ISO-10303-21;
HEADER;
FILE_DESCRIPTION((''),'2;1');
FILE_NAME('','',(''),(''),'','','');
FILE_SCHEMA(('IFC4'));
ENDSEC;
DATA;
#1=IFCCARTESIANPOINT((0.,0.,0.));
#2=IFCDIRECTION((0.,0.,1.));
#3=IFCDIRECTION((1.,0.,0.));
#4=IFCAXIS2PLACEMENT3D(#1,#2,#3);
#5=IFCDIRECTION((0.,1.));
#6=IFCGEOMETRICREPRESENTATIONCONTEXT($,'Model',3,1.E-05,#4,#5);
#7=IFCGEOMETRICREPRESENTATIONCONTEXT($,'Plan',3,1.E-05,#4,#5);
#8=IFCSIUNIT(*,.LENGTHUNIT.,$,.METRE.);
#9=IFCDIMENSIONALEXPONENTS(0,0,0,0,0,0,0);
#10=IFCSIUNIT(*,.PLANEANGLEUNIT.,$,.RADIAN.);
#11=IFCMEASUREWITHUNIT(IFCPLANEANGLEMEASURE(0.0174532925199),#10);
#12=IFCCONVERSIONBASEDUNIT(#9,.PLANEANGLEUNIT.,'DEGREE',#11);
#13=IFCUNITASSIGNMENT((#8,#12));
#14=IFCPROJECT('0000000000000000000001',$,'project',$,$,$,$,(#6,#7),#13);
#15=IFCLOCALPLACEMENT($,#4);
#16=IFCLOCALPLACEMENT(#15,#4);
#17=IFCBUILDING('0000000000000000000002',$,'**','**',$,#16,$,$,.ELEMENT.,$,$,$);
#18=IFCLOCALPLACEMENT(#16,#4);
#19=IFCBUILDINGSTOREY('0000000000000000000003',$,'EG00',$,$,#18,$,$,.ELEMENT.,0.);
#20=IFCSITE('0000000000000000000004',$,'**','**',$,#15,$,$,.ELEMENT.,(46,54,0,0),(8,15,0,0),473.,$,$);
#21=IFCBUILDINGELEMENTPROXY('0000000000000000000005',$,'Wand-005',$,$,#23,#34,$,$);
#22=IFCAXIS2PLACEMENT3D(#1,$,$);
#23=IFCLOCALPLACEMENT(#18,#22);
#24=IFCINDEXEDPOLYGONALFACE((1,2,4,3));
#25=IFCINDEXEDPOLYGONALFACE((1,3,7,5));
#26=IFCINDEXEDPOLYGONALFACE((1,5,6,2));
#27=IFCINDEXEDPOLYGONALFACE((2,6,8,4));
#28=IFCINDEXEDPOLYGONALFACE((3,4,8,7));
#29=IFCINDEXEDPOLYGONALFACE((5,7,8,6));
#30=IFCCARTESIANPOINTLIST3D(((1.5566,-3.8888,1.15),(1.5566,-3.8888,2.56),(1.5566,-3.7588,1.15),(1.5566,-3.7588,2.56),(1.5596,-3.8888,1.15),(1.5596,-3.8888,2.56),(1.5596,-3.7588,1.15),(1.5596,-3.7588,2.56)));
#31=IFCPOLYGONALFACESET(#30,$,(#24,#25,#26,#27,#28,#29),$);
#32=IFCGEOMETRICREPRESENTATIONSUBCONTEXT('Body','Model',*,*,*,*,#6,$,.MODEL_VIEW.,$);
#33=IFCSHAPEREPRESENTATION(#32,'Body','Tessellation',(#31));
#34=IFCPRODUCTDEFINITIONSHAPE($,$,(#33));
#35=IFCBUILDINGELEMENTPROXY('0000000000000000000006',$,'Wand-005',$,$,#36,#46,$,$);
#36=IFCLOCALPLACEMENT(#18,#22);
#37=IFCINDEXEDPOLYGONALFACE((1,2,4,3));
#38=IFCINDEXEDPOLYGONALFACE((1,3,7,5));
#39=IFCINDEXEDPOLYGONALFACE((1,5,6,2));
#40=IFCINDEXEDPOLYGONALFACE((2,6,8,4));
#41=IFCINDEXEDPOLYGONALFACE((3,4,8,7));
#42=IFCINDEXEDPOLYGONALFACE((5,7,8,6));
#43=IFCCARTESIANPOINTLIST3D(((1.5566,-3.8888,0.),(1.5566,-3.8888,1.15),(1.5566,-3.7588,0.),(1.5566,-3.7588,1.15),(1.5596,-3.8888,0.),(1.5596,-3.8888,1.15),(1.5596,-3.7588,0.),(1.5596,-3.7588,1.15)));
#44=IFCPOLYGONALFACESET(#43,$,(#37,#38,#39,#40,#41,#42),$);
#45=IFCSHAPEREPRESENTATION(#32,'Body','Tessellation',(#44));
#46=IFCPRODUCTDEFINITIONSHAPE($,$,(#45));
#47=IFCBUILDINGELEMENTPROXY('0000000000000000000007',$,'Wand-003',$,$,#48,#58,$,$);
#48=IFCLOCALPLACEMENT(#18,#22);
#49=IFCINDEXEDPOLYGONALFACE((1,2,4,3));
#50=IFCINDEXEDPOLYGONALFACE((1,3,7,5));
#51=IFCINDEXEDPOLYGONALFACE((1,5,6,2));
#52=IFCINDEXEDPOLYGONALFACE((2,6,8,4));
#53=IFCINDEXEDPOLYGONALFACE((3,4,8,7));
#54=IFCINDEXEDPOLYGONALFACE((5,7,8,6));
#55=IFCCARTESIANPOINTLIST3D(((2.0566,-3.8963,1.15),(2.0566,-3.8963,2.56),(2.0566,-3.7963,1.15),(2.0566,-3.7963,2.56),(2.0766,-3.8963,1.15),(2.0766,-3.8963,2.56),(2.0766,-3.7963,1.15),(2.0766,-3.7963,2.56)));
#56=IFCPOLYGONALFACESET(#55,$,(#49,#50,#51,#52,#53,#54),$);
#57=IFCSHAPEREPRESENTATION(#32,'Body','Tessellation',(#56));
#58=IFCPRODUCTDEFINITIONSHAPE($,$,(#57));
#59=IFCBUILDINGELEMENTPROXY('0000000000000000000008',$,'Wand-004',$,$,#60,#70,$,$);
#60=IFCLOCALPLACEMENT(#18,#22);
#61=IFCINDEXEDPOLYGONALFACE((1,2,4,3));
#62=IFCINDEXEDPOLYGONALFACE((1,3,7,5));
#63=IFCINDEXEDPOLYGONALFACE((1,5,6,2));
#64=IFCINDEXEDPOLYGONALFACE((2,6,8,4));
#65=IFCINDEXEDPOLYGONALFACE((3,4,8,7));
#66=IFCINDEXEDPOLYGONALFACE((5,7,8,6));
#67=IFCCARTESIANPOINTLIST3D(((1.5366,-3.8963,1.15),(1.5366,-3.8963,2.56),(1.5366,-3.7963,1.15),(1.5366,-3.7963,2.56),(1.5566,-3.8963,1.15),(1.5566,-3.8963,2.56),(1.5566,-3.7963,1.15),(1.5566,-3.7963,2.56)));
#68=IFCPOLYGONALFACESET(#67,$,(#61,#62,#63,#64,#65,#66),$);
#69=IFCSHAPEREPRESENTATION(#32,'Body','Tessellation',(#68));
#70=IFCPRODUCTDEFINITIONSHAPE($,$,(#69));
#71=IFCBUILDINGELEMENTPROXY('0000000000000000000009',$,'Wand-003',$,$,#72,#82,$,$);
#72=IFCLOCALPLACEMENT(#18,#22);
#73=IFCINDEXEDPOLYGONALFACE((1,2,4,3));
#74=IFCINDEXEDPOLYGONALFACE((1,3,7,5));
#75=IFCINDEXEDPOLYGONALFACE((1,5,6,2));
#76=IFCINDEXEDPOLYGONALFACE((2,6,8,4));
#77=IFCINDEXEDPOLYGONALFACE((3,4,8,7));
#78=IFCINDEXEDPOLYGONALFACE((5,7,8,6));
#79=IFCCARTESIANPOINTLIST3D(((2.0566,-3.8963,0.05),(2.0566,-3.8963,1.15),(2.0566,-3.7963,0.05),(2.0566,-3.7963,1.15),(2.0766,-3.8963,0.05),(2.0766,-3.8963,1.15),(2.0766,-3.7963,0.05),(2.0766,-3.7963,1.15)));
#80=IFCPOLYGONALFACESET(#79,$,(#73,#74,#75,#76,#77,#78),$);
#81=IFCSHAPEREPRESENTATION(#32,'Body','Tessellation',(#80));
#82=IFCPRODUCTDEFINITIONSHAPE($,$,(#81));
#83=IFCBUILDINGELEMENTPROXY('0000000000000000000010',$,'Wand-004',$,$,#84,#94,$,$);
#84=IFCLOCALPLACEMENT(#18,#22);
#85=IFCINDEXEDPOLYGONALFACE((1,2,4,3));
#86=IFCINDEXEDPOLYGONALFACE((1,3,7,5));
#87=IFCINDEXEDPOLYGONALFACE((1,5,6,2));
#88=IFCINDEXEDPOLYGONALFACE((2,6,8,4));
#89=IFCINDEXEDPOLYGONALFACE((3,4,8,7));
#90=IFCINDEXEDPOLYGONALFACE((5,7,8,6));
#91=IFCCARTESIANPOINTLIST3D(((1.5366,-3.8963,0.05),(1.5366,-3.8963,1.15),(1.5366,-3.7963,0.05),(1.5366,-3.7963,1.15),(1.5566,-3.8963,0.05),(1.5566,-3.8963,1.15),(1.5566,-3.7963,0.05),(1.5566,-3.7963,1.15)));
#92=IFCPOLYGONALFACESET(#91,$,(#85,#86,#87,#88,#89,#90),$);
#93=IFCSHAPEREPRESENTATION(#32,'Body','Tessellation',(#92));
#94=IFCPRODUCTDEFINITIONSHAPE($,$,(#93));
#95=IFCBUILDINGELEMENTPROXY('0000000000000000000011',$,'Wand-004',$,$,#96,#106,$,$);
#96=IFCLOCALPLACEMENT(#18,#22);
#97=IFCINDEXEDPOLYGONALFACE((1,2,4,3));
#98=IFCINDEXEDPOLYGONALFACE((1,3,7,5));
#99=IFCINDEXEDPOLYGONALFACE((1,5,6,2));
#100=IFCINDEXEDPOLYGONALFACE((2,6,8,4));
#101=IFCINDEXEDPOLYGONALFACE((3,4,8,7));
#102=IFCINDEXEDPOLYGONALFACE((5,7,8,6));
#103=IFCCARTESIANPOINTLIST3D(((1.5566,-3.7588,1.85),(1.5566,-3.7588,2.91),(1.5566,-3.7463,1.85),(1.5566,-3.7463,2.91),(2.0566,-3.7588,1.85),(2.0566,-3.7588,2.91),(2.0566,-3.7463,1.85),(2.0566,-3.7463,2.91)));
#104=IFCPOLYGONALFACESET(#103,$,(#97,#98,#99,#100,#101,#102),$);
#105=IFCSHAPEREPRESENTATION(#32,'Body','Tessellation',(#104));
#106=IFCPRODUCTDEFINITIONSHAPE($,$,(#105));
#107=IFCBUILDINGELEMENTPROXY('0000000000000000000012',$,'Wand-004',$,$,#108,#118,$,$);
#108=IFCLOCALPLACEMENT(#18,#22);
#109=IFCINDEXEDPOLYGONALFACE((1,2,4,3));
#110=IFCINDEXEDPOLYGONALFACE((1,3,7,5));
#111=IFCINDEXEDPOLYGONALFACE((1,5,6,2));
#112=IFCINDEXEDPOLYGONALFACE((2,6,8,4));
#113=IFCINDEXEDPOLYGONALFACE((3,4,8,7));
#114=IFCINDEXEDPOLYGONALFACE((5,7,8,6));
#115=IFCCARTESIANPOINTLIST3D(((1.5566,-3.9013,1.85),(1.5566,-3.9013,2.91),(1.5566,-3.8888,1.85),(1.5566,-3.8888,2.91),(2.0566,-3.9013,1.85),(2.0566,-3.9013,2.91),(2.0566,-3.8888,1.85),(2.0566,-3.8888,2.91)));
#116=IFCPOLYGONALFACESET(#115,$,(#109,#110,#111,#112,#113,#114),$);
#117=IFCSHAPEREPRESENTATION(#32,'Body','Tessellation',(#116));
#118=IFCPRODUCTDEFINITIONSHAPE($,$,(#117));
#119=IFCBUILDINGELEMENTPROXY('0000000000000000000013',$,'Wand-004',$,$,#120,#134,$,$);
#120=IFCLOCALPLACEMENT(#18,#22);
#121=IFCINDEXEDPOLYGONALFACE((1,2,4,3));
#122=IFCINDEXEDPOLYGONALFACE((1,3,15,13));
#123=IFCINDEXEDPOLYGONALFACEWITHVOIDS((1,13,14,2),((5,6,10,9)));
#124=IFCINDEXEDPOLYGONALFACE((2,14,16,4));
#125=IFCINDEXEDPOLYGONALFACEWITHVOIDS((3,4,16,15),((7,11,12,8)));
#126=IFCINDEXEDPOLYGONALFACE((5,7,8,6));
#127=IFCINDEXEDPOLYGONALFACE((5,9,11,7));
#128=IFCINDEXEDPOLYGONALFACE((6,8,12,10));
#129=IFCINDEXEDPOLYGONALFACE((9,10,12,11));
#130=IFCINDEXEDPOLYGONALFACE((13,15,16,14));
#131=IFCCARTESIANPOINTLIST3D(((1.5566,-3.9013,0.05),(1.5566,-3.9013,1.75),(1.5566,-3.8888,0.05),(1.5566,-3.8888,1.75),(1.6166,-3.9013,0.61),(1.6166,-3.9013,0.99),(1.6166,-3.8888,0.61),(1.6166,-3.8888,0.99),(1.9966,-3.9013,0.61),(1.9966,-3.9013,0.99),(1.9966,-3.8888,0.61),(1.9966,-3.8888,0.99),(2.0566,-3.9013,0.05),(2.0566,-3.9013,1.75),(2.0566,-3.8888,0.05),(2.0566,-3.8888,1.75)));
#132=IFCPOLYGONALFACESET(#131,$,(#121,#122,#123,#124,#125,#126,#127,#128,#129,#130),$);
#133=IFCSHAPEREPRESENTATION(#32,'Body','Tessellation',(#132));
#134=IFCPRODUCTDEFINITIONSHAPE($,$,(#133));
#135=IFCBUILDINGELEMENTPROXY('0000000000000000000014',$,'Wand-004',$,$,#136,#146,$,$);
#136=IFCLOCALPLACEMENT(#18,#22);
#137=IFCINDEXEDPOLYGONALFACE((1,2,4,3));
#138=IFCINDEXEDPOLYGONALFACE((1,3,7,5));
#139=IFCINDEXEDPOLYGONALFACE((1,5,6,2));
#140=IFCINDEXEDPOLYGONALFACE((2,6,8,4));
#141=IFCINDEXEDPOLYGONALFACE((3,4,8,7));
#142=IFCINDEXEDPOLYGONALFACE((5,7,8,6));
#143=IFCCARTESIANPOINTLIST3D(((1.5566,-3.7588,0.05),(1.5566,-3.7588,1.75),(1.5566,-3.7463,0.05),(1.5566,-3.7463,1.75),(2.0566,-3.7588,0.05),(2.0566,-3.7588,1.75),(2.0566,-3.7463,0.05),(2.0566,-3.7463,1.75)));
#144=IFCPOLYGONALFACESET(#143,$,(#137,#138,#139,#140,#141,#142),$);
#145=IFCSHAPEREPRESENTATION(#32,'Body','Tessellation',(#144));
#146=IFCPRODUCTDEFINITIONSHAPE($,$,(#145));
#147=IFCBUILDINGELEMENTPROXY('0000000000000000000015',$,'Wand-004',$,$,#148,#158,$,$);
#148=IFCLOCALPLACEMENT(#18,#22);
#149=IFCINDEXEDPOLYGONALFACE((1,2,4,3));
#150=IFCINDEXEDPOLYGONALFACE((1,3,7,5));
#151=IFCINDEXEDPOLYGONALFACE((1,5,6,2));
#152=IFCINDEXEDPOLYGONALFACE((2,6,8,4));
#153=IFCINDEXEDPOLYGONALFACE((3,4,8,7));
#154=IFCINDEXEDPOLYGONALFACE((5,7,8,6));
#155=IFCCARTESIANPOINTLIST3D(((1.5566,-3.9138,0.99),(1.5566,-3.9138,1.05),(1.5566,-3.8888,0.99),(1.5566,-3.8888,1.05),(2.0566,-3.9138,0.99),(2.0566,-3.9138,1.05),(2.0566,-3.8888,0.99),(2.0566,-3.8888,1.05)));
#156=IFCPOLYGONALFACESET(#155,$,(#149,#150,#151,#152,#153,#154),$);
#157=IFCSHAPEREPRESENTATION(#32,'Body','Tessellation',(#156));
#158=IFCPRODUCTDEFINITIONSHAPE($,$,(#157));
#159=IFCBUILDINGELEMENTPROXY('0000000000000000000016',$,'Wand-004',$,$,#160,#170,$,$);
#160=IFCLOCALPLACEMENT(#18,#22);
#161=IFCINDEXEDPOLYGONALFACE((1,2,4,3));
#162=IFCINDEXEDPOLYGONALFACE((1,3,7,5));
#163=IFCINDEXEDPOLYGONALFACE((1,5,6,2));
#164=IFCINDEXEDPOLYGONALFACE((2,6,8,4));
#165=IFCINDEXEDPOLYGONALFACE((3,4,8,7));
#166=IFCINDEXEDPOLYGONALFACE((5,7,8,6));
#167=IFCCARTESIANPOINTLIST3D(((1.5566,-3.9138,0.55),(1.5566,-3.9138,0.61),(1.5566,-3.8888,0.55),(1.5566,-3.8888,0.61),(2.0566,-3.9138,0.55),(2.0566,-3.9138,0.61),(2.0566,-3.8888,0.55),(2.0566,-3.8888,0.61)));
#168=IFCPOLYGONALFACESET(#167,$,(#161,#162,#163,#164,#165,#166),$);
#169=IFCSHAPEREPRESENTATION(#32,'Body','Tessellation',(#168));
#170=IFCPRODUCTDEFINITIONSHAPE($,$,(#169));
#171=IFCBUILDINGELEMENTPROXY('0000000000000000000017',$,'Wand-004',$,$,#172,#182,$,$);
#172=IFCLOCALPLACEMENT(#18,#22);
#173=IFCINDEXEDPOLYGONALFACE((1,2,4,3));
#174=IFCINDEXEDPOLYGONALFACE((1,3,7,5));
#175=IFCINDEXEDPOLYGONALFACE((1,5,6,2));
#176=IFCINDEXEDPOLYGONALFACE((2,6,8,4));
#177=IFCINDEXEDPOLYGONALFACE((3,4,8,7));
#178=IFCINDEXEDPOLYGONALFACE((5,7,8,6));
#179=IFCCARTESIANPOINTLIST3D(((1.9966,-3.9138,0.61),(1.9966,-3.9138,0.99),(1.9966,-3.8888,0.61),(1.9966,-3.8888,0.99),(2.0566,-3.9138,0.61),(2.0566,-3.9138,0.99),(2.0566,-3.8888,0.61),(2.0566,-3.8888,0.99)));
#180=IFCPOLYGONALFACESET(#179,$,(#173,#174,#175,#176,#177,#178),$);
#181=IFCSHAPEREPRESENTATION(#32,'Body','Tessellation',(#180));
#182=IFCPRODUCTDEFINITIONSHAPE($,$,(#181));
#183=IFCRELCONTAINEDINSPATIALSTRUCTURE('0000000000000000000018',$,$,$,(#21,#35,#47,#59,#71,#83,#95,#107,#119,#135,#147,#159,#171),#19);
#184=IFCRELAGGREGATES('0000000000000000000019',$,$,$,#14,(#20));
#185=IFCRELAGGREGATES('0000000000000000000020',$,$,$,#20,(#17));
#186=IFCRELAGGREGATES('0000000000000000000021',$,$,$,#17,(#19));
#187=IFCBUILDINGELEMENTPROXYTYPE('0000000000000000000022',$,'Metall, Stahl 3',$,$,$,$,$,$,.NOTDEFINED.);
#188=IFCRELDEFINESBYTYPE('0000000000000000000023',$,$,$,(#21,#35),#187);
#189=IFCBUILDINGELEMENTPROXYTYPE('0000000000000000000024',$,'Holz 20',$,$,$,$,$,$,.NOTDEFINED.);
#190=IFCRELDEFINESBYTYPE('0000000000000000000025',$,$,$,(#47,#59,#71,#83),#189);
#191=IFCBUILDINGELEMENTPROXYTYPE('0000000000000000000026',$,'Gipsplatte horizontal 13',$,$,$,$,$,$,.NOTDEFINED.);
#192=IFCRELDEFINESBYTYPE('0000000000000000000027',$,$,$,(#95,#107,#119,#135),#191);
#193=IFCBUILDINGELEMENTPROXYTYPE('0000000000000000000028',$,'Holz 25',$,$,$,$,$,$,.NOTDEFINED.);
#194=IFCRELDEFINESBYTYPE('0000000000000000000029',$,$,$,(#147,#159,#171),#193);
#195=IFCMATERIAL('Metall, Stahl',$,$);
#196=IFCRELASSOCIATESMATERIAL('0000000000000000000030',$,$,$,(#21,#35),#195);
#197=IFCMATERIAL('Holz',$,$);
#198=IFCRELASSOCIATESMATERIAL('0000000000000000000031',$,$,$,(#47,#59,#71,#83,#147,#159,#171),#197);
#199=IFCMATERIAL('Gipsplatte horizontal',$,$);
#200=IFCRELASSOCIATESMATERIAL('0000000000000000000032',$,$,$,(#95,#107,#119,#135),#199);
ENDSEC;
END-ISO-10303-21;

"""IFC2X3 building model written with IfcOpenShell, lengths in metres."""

from ifc_helpers import new_model, entity, si_unit, converted_unit, direction, frame, origin_with_axes, origin_2d_with_axis, place, context, subcontext, project, spatial, polyline, rectangle, outline, extrude, material, type_object, element, save


model = new_model("IFC2X3")

# Units and contexts
model_context = context("Model", 3, precision=1e-05, world=origin_with_axes(), true_north=direction((0.0, 1.0)))
plan_context = context("Plan", 3, precision=1e-05, world=origin_with_axes(), true_north=direction((0.0, 1.0)))
body_context = subcontext(model_context, "Body", "Model", "MODEL_VIEW")
ifc_project = project(units=[si_unit("LENGTHUNIT", "METRE"), converted_unit("PLANEANGLEUNIT", "DEGREE", entity("IfcPlaneAngleMeasure", 0.0174532925199), si_unit("PLANEANGLEUNIT", "RADIAN"), dimensions=[0, 0, 0, 0, 0, 0, 0])], contexts=[model_context, plan_context])

# Site, building, storey
site_placement = place(None, origin_with_axes())
site = spatial("IfcSite", under=ifc_project, at=site_placement, Name="**", Description="**", CompositionType="ELEMENT", RefLatitude=(46, 54, 0, 0), RefLongitude=(8, 15, 0, 0), RefElevation=473.0)
building_placement = place(site_placement, origin_with_axes())
building = spatial("IfcBuilding", under=site, at=building_placement, Name="**", Description="**", CompositionType="ELEMENT")
storey_placement = place(building_placement, origin_with_axes())
storey = spatial("IfcBuildingStorey", under=building, at=storey_placement, Name="EG00", CompositionType="ELEMENT", Elevation=0.0)

# Building element proxies
ifc_material_1 = material(Name="Metall, Stahl")
building_element_proxy_type_1 = type_object("IfcBuildingElementProxyType", Name="Metall, Stahl 3", PredefinedType="NOTDEFINED")
proxy_1_placement = place(storey_placement, frame((1.5566, -3.7588, 1.15), z_axis=(0.0, 0.0, 1.0), x_axis=(0.0, -1.0, 0.0)))
element("IfcBuildingElementProxy", 1, at=proxy_1_placement, inside=storey, type_object=building_element_proxy_type_1, material=ifc_material_1, Name="Wand-005", context=body_context, shape_type="SweptSolid", body=[
    extrude(outline(polyline([(0.0, 0.0), (0.13, 0.0), (0.13, 0.003), (0.0, 0.003), (0.0, 0.0)])), origin_with_axes(), (0.0, 0.0, 1.0), 1.41),
])
proxy_2_placement = place(storey_placement, frame((1.5566, -3.7588, 0.0), z_axis=(0.0, 0.0, 1.0), x_axis=(0.0, -1.0, 0.0)))
element("IfcBuildingElementProxy", 2, at=proxy_2_placement, inside=storey, type_object=building_element_proxy_type_1, material=ifc_material_1, Name="Wand-005", context=body_context, shape_type="SweptSolid", body=[
    extrude(outline(polyline([(0.0, 0.0), (0.13, 0.0), (0.13, 0.003), (0.0, 0.003), (0.0, 0.0)])), origin_with_axes(), (0.0, 0.0, 1.0), 1.15),
])
ifc_material_2 = material(Name="Holz")
building_element_proxy_type_2 = type_object("IfcBuildingElementProxyType", Name="Holz 20", PredefinedType="NOTDEFINED")
proxy_3_placement = place(storey_placement, frame((2.0766, -3.7963, 1.15), z_axis=(0.0, 0.0, 1.0), x_axis=(0.0, -1.0, 0.0)))
element("IfcBuildingElementProxy", 3, at=proxy_3_placement, inside=storey, type_object=building_element_proxy_type_2, material=ifc_material_2, Name="Wand-003", context=body_context, shape_type="SweptSolid", body=[
    extrude(outline(polyline([(0.0, -0.02), (0.1, -0.02), (0.1, 0.0), (0.0, 0.0), (0.0, -0.02)])), origin_with_axes(), (0.0, 0.0, 1.0), 1.41),
])
proxy_4_placement = place(storey_placement, frame((1.5366, -3.7963, 1.15), z_axis=(0.0, 0.0, 1.0), x_axis=(0.0, -1.0, 0.0)))
element("IfcBuildingElementProxy", 4, at=proxy_4_placement, inside=storey, type_object=building_element_proxy_type_2, material=ifc_material_2, Name="Wand-004", context=body_context, shape_type="SweptSolid", body=[
    extrude(outline(polyline([(0.0, 0.0), (0.1, 0.0), (0.1, 0.02), (0.0, 0.02), (0.0, 0.0)])), origin_with_axes(), (0.0, 0.0, 1.0), 1.41),
])
proxy_5_placement = place(storey_placement, frame((2.0766, -3.7963, 0.05), z_axis=(0.0, 0.0, 1.0), x_axis=(0.0, -1.0, 0.0)))
element("IfcBuildingElementProxy", 5, at=proxy_5_placement, inside=storey, type_object=building_element_proxy_type_2, material=ifc_material_2, Name="Wand-003", context=body_context, shape_type="SweptSolid", body=[
    extrude(outline(polyline([(0.0, -0.02), (0.1, -0.02), (0.1, 0.0), (0.0, 0.0), (0.0, -0.02)])), origin_with_axes(), (0.0, 0.0, 1.0), 1.1),
])
proxy_6_placement = place(storey_placement, frame((1.5366, -3.7963, 0.05), z_axis=(0.0, 0.0, 1.0), x_axis=(0.0, -1.0, 0.0)))
element("IfcBuildingElementProxy", 6, at=proxy_6_placement, inside=storey, type_object=building_element_proxy_type_2, material=ifc_material_2, Name="Wand-004", context=body_context, shape_type="SweptSolid", body=[
    extrude(outline(polyline([(0.0, 0.0), (0.1, 0.0), (0.1, 0.02), (0.0, 0.02), (0.0, 0.0)])), origin_with_axes(), (0.0, 0.0, 1.0), 1.1),
])
ifc_material_3 = material(Name="Gipsplatte horizontal")
building_element_proxy_type_3 = type_object("IfcBuildingElementProxyType", Name="Gipsplatte horizontal 13", PredefinedType="NOTDEFINED")
proxy_7_placement = place(storey_placement, frame((1.5566, -3.7463, 1.85), z_axis=(0.0, 0.0, 1.0), x_axis=(1.0, 0.0, 0.0)))
element("IfcBuildingElementProxy", 7, at=proxy_7_placement, inside=storey, type_object=building_element_proxy_type_3, material=ifc_material_3, Name="Wand-004", context=body_context, shape_type="SweptSolid", body=[
    extrude(outline(polyline([(0.0, -0.0125), (0.5, -0.0125), (0.5, 0.0), (0.0, 0.0), (0.0, -0.0125)])), origin_with_axes(), (0.0, 0.0, 1.0), 1.06),
])
proxy_8_placement = place(storey_placement, frame((1.5566, -3.9013, 1.85), z_axis=(0.0, 0.0, 1.0), x_axis=(1.0, 0.0, 0.0)))
element("IfcBuildingElementProxy", 8, at=proxy_8_placement, inside=storey, type_object=building_element_proxy_type_3, material=ifc_material_3, Name="Wand-004", context=body_context, shape_type="SweptSolid", body=[
    extrude(outline(polyline([(0.0, 0.0), (0.5, 0.0), (0.5, 0.0125), (0.0, 0.0125), (0.0, 0.0)])), origin_with_axes(), (0.0, 0.0, 1.0), 1.06),
])

# Building element proxy, opening
proxy_9_placement = place(storey_placement, frame((1.5566, -3.9013, 0.05), z_axis=(0.0, 0.0, 1.0), x_axis=(1.0, 0.0, 0.0)))
proxy_9 = element("IfcBuildingElementProxy", 9, at=proxy_9_placement, inside=storey, type_object=building_element_proxy_type_3, material=ifc_material_3, Name="Wand-004", context=body_context, shape_type="SweptSolid", body=[
    extrude(outline(polyline([(0.0, 0.0), (0.5, 0.0), (0.5, 0.0125), (0.0, 0.0125), (0.0, 0.0)])), origin_with_axes(), (0.0, 0.0, 1.0), 1.7),
])
opening_placement = place(proxy_9_placement, frame((-1.5566, 3.9013, -0.05), z_axis=(0.0, 0.0, 1.0), x_axis=(1.0, 0.0, 0.0)))
element("IfcOpeningElement", 10, at=opening_placement, cuts=proxy_9, context=body_context, shape_type="SweptSolid", body=[
    extrude(rectangle(XDim=0.38, YDim=0.38, at=origin_2d_with_axis()), frame((1.8066, -3.9138, 0.8), z_axis=(0.0, -1.0, 0.0), x_axis=(1.0, 0.0, 0.0)), (0.0, 0.0, -1.0), 0.0375),
])

# Building element proxies
proxy_10_placement = place(storey_placement, frame((1.5566, -3.7463, 0.05), z_axis=(0.0, 0.0, 1.0), x_axis=(1.0, 0.0, 0.0)))
element("IfcBuildingElementProxy", 11, at=proxy_10_placement, inside=storey, type_object=building_element_proxy_type_3, material=ifc_material_3, Name="Wand-004", context=body_context, shape_type="SweptSolid", body=[
    extrude(outline(polyline([(0.0, -0.0125), (0.5, -0.0125), (0.5, 0.0), (0.0, 0.0), (0.0, -0.0125)])), origin_with_axes(), (0.0, 0.0, 1.0), 1.7),
])
building_element_proxy_type_4 = type_object("IfcBuildingElementProxyType", Name="Holz 25", PredefinedType="NOTDEFINED")
for number, where, z_axis, x_axis, name in (
    (12, (2.0566, -3.8888, 0.99), (0.0, 0.0, 1.0), (-1.0, 0.0, 0.0), "Wand-004"),
    (13, (2.0566, -3.8888, 0.55), (0.0, 0.0, 1.0), (-1.0, 0.0, 0.0), "Wand-004"),
):
    element("IfcBuildingElementProxy", number, at=place(storey_placement, frame(where, z_axis=z_axis, x_axis=x_axis)), inside=storey, type_object=building_element_proxy_type_4, material=ifc_material_2, Name=name, context=body_context, shape_type="SweptSolid", body=[
        extrude(outline(polyline([(0.0, 0.0), (0.5, 0.0), (0.5, 0.025), (0.0, 0.025), (0.0, 0.0)])), origin_with_axes(), (0.0, 0.0, 1.0), 0.06),
    ])
for number, where, z_axis, x_axis, name in (
    (14, (1.9966, -3.9138, 0.61), (0.0, 0.0, 1.0), (1.0, 0.0, 0.0), "Wand-004"),
):
    element("IfcBuildingElementProxy", number, at=place(storey_placement, frame(where, z_axis=z_axis, x_axis=x_axis)), inside=storey, type_object=building_element_proxy_type_4, material=ifc_material_2, Name=name, context=body_context, shape_type="SweptSolid", body=[
        extrude(outline(polyline([(0.0, 0.0), (0.06, 0.0), (0.06, 0.025), (0.0, 0.025), (0.0, 0.0)])), origin_with_axes(), (0.0, 0.0, 1.0), 0.38),
    ])

save(model, "model.ifc")
